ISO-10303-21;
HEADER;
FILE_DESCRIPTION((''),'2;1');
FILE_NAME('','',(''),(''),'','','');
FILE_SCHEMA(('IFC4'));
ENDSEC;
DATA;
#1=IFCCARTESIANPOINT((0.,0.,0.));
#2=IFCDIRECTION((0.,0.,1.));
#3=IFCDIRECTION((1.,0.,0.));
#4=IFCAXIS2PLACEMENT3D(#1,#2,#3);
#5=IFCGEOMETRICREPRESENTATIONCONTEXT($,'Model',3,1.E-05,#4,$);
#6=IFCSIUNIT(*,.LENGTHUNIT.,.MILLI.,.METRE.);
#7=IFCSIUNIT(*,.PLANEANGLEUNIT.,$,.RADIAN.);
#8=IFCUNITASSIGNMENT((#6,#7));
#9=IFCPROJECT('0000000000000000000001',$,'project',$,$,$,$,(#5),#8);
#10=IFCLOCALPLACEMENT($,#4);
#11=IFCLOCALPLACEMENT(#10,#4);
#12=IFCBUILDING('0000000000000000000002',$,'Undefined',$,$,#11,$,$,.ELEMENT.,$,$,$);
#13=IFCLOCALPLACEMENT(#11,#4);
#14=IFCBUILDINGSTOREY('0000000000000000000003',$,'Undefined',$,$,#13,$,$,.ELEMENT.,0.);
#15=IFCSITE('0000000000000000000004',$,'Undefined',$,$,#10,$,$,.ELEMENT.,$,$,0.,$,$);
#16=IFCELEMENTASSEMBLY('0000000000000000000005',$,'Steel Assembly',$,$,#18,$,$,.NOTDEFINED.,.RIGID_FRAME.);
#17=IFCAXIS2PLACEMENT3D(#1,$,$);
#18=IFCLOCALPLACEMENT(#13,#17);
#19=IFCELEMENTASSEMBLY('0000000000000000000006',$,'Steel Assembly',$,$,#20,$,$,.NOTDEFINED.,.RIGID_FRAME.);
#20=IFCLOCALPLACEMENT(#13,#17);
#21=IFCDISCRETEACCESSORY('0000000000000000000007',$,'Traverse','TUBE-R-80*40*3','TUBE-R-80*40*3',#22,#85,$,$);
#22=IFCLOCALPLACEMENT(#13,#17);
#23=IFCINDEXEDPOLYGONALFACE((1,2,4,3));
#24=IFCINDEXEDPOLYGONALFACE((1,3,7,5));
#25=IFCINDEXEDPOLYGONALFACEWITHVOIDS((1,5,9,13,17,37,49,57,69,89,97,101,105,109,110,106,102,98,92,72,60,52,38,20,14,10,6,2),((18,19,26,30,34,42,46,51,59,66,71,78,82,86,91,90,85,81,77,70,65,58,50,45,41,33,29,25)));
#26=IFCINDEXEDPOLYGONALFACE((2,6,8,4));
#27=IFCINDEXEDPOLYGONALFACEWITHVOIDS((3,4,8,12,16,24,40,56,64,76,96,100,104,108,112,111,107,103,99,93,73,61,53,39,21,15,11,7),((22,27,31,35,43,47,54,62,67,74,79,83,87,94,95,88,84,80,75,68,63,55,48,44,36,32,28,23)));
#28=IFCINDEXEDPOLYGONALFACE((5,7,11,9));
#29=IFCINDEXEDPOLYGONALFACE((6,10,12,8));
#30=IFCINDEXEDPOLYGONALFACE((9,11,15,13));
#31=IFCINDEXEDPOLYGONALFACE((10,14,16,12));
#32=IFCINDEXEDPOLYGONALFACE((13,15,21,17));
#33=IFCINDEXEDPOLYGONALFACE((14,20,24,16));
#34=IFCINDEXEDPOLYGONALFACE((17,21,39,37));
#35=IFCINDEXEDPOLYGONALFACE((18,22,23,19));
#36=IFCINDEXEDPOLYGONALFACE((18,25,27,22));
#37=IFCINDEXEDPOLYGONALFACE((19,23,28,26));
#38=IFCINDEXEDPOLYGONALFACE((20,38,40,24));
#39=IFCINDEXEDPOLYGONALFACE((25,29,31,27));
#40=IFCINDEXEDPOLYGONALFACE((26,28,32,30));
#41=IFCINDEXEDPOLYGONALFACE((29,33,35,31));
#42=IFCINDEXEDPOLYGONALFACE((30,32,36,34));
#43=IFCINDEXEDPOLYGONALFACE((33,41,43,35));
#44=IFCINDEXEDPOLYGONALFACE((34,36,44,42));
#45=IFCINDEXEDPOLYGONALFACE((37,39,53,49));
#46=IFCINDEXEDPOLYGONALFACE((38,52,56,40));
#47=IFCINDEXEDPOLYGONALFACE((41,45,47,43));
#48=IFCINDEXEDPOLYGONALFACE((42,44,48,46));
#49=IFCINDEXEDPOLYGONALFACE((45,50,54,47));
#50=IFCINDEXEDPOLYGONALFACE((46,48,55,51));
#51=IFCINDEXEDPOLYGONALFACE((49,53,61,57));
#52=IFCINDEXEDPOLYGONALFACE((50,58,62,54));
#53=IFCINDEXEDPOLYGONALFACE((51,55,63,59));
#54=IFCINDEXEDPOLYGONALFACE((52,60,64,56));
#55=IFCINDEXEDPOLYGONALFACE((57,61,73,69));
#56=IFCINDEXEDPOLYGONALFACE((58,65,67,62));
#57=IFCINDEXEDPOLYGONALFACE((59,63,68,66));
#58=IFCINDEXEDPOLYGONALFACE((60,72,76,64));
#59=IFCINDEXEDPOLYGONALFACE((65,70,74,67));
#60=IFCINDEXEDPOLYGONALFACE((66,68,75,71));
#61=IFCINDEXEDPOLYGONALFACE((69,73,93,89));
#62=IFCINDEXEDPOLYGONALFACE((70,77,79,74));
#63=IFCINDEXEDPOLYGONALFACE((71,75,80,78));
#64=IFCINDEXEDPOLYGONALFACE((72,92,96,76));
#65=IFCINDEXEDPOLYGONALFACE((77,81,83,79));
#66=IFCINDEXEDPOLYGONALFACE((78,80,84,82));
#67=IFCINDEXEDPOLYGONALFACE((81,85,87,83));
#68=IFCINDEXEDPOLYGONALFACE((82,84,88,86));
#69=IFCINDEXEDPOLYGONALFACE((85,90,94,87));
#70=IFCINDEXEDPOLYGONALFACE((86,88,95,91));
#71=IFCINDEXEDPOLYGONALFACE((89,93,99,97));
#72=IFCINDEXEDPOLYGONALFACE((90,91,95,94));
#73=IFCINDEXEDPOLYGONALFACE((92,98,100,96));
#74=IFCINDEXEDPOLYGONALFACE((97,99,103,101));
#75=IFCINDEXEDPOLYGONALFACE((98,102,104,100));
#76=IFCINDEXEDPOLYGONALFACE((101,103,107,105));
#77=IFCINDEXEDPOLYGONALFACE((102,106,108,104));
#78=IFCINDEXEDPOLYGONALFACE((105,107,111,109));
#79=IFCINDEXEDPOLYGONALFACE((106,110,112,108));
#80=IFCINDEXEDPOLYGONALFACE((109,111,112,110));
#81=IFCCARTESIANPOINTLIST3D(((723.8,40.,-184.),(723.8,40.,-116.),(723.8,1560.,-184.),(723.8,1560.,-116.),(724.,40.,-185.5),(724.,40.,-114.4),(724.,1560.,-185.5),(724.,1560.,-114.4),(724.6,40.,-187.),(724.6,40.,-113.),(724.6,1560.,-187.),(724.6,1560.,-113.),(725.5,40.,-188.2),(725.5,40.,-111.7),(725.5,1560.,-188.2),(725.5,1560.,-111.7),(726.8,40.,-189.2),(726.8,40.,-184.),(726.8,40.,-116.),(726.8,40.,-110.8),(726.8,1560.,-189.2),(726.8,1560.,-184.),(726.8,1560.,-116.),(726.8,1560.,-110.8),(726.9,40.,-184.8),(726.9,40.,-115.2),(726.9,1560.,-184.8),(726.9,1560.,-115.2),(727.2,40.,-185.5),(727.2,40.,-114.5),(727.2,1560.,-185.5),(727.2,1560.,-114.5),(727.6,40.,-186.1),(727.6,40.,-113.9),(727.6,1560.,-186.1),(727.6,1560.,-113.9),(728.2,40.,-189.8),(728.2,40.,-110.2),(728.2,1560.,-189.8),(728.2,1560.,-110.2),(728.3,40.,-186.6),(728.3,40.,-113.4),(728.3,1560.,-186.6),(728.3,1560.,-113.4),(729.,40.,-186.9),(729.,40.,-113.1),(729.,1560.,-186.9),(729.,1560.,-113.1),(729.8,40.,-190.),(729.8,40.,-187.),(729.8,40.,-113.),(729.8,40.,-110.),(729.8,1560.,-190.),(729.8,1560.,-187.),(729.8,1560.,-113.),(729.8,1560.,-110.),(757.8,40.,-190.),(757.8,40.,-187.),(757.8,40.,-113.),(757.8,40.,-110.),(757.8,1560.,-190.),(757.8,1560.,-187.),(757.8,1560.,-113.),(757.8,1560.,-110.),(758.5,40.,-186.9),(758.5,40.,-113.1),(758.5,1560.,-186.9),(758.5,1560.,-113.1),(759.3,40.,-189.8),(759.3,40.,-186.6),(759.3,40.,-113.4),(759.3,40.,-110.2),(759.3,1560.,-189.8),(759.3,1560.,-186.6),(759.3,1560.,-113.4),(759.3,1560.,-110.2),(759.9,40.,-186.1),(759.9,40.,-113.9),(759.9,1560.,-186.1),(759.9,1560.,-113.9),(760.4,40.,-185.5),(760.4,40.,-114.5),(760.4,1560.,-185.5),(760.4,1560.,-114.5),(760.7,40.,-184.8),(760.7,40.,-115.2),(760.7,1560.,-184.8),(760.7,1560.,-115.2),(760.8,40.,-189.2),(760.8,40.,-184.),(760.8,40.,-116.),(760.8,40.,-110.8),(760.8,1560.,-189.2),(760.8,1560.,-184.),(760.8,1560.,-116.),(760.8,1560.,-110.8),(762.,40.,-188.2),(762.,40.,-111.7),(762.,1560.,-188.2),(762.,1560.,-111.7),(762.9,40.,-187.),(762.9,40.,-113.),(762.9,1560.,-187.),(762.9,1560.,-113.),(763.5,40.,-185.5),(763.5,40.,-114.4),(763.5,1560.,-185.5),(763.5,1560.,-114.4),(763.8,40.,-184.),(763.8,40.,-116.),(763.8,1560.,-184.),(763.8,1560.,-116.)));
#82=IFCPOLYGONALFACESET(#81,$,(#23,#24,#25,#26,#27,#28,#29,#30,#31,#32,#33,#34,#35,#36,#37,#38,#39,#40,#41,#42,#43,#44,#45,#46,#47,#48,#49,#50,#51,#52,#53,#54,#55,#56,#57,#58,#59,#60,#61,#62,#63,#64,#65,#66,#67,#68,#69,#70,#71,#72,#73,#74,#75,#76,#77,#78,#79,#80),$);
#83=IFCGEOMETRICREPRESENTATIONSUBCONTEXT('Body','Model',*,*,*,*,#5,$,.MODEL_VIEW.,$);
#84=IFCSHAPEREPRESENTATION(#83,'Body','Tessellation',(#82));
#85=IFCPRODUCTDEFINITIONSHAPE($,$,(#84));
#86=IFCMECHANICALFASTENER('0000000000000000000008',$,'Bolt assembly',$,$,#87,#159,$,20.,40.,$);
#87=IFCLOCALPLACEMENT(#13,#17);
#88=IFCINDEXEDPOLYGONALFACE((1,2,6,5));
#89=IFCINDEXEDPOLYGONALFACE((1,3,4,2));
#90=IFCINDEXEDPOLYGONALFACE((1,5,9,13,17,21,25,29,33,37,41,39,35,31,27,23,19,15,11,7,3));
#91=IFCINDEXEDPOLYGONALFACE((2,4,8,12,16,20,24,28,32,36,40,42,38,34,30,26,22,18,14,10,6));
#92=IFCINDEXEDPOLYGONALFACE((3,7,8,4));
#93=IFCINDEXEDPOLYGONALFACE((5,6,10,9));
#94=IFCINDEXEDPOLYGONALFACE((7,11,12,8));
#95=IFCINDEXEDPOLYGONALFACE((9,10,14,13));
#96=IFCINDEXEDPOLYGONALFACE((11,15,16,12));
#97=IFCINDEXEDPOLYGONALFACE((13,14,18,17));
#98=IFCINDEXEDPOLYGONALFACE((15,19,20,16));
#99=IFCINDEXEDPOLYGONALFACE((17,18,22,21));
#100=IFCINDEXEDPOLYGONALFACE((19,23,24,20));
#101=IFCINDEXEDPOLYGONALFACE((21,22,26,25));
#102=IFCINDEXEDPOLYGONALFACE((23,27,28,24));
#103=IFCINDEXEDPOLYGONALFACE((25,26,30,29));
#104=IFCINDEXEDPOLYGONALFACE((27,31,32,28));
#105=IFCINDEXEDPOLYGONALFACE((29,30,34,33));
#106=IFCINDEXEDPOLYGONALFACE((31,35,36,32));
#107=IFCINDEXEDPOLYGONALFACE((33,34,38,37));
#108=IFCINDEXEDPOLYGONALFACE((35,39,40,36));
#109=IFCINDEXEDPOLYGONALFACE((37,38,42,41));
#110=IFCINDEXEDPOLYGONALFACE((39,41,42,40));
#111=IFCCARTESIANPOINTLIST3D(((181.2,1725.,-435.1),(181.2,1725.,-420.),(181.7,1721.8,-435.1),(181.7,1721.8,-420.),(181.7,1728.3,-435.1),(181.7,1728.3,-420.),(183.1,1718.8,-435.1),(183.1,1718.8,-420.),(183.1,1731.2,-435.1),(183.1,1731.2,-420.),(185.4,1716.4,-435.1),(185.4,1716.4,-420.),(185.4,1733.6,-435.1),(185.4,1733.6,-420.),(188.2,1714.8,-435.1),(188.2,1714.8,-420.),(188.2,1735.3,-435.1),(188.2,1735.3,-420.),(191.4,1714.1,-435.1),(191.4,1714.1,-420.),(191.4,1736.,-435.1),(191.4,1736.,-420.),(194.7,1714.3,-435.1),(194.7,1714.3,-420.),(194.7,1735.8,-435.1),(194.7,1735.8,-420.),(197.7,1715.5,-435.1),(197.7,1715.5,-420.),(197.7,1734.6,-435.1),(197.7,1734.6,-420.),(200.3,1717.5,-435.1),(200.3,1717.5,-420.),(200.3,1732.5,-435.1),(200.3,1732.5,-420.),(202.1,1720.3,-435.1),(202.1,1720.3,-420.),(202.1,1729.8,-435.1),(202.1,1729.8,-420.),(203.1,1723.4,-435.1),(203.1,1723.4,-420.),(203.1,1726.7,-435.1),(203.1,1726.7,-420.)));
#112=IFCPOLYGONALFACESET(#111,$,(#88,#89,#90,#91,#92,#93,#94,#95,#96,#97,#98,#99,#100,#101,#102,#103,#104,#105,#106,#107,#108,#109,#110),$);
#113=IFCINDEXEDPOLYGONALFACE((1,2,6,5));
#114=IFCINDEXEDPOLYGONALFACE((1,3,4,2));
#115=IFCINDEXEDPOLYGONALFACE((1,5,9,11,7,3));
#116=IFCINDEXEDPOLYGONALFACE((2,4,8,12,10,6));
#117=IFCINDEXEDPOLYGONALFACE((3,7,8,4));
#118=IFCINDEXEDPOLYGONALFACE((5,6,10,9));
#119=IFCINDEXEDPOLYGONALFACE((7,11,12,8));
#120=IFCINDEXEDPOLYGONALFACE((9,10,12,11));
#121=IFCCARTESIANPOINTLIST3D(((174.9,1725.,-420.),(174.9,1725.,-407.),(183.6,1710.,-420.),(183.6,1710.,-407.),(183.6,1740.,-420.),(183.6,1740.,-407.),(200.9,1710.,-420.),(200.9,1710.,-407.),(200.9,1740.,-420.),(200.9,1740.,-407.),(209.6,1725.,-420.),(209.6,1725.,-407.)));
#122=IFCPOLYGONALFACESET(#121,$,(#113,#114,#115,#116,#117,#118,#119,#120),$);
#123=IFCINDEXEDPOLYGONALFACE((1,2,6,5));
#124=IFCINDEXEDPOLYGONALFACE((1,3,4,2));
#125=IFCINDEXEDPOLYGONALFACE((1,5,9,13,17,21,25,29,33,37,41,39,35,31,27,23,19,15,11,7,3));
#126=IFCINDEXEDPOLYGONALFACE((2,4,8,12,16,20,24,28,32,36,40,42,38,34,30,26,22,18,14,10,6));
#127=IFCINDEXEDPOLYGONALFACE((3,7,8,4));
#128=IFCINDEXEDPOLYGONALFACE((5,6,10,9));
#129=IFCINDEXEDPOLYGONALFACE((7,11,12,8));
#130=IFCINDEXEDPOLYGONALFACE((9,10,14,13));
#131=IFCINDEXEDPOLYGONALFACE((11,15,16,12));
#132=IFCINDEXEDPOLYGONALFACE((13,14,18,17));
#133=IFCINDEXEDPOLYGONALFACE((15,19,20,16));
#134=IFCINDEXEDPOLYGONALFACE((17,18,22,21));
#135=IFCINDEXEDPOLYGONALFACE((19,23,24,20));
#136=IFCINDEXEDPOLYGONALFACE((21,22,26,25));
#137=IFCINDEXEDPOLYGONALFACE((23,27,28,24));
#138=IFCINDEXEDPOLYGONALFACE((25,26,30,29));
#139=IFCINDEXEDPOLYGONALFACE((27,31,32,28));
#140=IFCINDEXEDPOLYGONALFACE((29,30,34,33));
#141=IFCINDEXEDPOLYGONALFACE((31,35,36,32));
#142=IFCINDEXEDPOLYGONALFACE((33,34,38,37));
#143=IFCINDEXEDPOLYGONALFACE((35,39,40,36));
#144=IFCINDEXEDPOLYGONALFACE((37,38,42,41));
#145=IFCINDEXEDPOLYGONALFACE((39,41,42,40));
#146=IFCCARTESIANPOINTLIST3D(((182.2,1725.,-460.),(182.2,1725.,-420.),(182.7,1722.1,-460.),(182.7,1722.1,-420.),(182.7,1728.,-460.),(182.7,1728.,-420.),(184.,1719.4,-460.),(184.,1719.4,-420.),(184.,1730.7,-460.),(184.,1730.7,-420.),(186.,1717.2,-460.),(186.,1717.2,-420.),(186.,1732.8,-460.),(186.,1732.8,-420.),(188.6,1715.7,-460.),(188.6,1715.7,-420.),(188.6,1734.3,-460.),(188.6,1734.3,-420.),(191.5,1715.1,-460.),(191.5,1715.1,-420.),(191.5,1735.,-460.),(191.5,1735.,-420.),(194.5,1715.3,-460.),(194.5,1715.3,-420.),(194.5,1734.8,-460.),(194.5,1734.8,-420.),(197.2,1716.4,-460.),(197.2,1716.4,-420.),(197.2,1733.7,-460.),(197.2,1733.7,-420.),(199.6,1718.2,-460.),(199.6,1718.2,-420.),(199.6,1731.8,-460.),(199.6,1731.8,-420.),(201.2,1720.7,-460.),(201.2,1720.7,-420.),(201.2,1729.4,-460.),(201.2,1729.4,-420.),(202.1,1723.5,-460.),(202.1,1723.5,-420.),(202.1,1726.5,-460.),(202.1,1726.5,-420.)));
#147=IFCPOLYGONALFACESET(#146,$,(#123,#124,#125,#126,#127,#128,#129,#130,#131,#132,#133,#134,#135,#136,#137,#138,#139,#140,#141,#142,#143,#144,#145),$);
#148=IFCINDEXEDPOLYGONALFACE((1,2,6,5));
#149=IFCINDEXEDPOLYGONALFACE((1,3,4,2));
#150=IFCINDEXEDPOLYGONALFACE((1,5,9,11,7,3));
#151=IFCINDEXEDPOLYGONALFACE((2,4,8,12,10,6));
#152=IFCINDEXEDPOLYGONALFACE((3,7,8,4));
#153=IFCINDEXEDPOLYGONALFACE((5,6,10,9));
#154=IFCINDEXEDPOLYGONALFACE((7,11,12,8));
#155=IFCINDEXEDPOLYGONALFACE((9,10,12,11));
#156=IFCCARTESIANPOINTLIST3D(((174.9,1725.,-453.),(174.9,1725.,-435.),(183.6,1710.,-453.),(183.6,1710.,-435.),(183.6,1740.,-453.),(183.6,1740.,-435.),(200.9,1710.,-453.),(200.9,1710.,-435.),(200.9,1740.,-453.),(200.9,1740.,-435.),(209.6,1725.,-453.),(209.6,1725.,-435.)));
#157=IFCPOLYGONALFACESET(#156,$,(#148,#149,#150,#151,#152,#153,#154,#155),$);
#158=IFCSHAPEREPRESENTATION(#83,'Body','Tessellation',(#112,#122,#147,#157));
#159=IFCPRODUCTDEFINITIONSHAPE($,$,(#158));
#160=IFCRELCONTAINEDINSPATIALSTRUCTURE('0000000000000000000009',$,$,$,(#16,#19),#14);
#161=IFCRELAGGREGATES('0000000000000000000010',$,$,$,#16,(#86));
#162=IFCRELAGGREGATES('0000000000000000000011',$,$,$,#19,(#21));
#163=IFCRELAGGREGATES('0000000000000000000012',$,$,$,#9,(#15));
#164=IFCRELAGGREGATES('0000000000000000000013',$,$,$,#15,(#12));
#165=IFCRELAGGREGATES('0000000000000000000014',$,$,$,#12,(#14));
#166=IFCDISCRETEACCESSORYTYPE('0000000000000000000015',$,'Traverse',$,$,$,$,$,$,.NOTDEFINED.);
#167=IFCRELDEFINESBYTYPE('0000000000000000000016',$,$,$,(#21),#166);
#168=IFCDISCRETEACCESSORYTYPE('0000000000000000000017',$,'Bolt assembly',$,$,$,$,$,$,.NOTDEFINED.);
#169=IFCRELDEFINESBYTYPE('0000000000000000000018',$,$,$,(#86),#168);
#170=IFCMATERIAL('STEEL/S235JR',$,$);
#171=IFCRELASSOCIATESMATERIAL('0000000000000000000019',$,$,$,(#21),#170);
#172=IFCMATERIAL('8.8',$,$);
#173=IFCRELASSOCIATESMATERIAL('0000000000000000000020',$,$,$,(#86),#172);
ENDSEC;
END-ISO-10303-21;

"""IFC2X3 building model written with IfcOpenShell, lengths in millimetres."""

from ifc_helpers import new_model, si_unit, frame, origin_with_axes, origin_2d_with_axis, place, context, subcontext, project, spatial, polyline, hollow_rectangle, circle, outline, extrude, source, transform, mapped, material, type_object, element, aggregate, save


model = new_model("IFC2X3")

# Units and contexts
model_context = context("Model", 3, precision=1e-05, world=origin_with_axes())
body_context = subcontext(model_context, "Body", "Model", "MODEL_VIEW")
ifc_project = project(units=[si_unit("LENGTHUNIT", "METRE", prefix="MILLI"), si_unit("PLANEANGLEUNIT", "RADIAN")], contexts=[model_context])

# Site, building, storey
site_placement = place(None, origin_with_axes())
site = spatial("IfcSite", under=ifc_project, at=site_placement, Name="Undefined", CompositionType="ELEMENT", RefElevation=0.0)
building_placement = place(site_placement, origin_with_axes())
building = spatial("IfcBuilding", under=site, at=building_placement, Name="Undefined", CompositionType="ELEMENT")
storey_placement = place(building_placement, origin_with_axes())
storey = spatial("IfcBuildingStorey", under=building, at=storey_placement, Name="Undefined", CompositionType="ELEMENT", Elevation=0.0)

# Element assembly
ifc_material_1 = material(Name="STEEL/S235JR")
assembly_1_placement = place(storey_placement, origin_with_axes())
assembly_1 = element("IfcElementAssembly", 1, at=assembly_1_placement, inside=storey, Name="Steel Assembly", AssemblyPlace="NOTDEFINED", PredefinedType="RIGID_FRAME")

# Element assembly
assembly_2_placement = place(storey_placement, origin_with_axes())
assembly_2 = element("IfcElementAssembly", 2, at=assembly_2_placement, inside=storey, Name="Steel Assembly", AssemblyPlace="NOTDEFINED", PredefinedType="RIGID_FRAME")
discrete_accessory_type_1 = type_object("IfcDiscreteAccessoryType", Name="Traverse")

# Discrete accessory
discrete_accessory_1_placement = place(assembly_2_placement, frame((743.8, 1560.0, -150.0), z_axis=(0.0, 0.0, 1.0), x_axis=(0.0, -1.0, 0.0)))
discrete_accessory_1 = element("IfcDiscreteAccessory", 3, at=discrete_accessory_1_placement, type_object=discrete_accessory_type_1, material=ifc_material_1, Name="Traverse", Description="TUBE-R-80*40*3", ObjectType="TUBE-R-80*40*3", context=body_context, shape_type="SweptSolid", body=[
    extrude(hollow_rectangle(XDim=40.0, YDim=80.0, WallThickness=3.0, InnerFilletRadius=3.0, OuterFilletRadius=6.0, at=origin_2d_with_axis()), frame((1520.0, 0.0, 0.0), z_axis=(-1.0, 0.0, 0.0), x_axis=(0.0, -1.0, 0.0)), (0.0, 0.0, 1.0), 1520.0),
])

# Mechanical fastener
ifc_material_2 = material(Name="8.8")
discrete_accessory_type_2 = type_object("IfcDiscreteAccessoryType", Name="Bolt assembly")
shared_shape_1 = source(origin_with_axes(), body_context, "Body", "SweptSolid", [
    extrude(circle(Radius=11.0, at=origin_2d_with_axis()), frame((0.0, 0.0, 0.0), z_axis=(0.0, 1.0, 0.0), x_axis=(1.0, 0.0, 0.0)), (0.0, 0.0, 1.0), 15.1),
    extrude(outline(polyline([(17.3, 0.0), (8.7, 15.0), (-8.7, 15.0), (-17.3, 0.0), (-8.7, -15.0), (8.7, -15.0), (17.3, 0.0)])), frame((0.0, -13.0, 0.0), z_axis=(0.0, 1.0, 0.0), x_axis=(1.0, 0.0, 0.0)), (0.0, 0.0, 1.0), 13.0),
    extrude(circle(Radius=10.0, at=origin_2d_with_axis()), frame((0.0, 0.0, 0.0), z_axis=(0.0, 1.0, 0.0), x_axis=(1.0, 0.0, 0.0)), (0.0, 0.0, 1.0), 40.0),
    extrude(outline(polyline([(17.3, 0.0), (8.7, 15.0), (-8.7, 15.0), (-17.3, 0.0), (-8.7, -15.0), (8.7, -15.0), (17.3, 0.0)])), frame((0.0, 15.0, 0.0), z_axis=(0.0, 1.0, 0.0), x_axis=(1.0, 0.0, 0.0)), (0.0, 0.0, 1.0), 18.0),
])
mechanical_fastener_1_placement = place(assembly_1_placement, frame((192.2, 1725.0, -420.0), z_axis=(0.0, -1.0, 0.0), x_axis=(-1.0, 0.0, 0.0)))
mechanical_fastener_1 = element("IfcMechanicalFastener", 4, at=mechanical_fastener_1_placement, type_object=discrete_accessory_type_2, material=ifc_material_2, Name="Bolt assembly", NominalDiameter=20.0, NominalLength=40.0, context=body_context, shape_type="MappedRepresentation", body=[
    mapped(shared_shape_1, transform((0.0, 0.0, 0.0))),
])

aggregate(assembly_1, [mechanical_fastener_1])

aggregate(assembly_2, [discrete_accessory_1])

save(model, "model.ifc")
